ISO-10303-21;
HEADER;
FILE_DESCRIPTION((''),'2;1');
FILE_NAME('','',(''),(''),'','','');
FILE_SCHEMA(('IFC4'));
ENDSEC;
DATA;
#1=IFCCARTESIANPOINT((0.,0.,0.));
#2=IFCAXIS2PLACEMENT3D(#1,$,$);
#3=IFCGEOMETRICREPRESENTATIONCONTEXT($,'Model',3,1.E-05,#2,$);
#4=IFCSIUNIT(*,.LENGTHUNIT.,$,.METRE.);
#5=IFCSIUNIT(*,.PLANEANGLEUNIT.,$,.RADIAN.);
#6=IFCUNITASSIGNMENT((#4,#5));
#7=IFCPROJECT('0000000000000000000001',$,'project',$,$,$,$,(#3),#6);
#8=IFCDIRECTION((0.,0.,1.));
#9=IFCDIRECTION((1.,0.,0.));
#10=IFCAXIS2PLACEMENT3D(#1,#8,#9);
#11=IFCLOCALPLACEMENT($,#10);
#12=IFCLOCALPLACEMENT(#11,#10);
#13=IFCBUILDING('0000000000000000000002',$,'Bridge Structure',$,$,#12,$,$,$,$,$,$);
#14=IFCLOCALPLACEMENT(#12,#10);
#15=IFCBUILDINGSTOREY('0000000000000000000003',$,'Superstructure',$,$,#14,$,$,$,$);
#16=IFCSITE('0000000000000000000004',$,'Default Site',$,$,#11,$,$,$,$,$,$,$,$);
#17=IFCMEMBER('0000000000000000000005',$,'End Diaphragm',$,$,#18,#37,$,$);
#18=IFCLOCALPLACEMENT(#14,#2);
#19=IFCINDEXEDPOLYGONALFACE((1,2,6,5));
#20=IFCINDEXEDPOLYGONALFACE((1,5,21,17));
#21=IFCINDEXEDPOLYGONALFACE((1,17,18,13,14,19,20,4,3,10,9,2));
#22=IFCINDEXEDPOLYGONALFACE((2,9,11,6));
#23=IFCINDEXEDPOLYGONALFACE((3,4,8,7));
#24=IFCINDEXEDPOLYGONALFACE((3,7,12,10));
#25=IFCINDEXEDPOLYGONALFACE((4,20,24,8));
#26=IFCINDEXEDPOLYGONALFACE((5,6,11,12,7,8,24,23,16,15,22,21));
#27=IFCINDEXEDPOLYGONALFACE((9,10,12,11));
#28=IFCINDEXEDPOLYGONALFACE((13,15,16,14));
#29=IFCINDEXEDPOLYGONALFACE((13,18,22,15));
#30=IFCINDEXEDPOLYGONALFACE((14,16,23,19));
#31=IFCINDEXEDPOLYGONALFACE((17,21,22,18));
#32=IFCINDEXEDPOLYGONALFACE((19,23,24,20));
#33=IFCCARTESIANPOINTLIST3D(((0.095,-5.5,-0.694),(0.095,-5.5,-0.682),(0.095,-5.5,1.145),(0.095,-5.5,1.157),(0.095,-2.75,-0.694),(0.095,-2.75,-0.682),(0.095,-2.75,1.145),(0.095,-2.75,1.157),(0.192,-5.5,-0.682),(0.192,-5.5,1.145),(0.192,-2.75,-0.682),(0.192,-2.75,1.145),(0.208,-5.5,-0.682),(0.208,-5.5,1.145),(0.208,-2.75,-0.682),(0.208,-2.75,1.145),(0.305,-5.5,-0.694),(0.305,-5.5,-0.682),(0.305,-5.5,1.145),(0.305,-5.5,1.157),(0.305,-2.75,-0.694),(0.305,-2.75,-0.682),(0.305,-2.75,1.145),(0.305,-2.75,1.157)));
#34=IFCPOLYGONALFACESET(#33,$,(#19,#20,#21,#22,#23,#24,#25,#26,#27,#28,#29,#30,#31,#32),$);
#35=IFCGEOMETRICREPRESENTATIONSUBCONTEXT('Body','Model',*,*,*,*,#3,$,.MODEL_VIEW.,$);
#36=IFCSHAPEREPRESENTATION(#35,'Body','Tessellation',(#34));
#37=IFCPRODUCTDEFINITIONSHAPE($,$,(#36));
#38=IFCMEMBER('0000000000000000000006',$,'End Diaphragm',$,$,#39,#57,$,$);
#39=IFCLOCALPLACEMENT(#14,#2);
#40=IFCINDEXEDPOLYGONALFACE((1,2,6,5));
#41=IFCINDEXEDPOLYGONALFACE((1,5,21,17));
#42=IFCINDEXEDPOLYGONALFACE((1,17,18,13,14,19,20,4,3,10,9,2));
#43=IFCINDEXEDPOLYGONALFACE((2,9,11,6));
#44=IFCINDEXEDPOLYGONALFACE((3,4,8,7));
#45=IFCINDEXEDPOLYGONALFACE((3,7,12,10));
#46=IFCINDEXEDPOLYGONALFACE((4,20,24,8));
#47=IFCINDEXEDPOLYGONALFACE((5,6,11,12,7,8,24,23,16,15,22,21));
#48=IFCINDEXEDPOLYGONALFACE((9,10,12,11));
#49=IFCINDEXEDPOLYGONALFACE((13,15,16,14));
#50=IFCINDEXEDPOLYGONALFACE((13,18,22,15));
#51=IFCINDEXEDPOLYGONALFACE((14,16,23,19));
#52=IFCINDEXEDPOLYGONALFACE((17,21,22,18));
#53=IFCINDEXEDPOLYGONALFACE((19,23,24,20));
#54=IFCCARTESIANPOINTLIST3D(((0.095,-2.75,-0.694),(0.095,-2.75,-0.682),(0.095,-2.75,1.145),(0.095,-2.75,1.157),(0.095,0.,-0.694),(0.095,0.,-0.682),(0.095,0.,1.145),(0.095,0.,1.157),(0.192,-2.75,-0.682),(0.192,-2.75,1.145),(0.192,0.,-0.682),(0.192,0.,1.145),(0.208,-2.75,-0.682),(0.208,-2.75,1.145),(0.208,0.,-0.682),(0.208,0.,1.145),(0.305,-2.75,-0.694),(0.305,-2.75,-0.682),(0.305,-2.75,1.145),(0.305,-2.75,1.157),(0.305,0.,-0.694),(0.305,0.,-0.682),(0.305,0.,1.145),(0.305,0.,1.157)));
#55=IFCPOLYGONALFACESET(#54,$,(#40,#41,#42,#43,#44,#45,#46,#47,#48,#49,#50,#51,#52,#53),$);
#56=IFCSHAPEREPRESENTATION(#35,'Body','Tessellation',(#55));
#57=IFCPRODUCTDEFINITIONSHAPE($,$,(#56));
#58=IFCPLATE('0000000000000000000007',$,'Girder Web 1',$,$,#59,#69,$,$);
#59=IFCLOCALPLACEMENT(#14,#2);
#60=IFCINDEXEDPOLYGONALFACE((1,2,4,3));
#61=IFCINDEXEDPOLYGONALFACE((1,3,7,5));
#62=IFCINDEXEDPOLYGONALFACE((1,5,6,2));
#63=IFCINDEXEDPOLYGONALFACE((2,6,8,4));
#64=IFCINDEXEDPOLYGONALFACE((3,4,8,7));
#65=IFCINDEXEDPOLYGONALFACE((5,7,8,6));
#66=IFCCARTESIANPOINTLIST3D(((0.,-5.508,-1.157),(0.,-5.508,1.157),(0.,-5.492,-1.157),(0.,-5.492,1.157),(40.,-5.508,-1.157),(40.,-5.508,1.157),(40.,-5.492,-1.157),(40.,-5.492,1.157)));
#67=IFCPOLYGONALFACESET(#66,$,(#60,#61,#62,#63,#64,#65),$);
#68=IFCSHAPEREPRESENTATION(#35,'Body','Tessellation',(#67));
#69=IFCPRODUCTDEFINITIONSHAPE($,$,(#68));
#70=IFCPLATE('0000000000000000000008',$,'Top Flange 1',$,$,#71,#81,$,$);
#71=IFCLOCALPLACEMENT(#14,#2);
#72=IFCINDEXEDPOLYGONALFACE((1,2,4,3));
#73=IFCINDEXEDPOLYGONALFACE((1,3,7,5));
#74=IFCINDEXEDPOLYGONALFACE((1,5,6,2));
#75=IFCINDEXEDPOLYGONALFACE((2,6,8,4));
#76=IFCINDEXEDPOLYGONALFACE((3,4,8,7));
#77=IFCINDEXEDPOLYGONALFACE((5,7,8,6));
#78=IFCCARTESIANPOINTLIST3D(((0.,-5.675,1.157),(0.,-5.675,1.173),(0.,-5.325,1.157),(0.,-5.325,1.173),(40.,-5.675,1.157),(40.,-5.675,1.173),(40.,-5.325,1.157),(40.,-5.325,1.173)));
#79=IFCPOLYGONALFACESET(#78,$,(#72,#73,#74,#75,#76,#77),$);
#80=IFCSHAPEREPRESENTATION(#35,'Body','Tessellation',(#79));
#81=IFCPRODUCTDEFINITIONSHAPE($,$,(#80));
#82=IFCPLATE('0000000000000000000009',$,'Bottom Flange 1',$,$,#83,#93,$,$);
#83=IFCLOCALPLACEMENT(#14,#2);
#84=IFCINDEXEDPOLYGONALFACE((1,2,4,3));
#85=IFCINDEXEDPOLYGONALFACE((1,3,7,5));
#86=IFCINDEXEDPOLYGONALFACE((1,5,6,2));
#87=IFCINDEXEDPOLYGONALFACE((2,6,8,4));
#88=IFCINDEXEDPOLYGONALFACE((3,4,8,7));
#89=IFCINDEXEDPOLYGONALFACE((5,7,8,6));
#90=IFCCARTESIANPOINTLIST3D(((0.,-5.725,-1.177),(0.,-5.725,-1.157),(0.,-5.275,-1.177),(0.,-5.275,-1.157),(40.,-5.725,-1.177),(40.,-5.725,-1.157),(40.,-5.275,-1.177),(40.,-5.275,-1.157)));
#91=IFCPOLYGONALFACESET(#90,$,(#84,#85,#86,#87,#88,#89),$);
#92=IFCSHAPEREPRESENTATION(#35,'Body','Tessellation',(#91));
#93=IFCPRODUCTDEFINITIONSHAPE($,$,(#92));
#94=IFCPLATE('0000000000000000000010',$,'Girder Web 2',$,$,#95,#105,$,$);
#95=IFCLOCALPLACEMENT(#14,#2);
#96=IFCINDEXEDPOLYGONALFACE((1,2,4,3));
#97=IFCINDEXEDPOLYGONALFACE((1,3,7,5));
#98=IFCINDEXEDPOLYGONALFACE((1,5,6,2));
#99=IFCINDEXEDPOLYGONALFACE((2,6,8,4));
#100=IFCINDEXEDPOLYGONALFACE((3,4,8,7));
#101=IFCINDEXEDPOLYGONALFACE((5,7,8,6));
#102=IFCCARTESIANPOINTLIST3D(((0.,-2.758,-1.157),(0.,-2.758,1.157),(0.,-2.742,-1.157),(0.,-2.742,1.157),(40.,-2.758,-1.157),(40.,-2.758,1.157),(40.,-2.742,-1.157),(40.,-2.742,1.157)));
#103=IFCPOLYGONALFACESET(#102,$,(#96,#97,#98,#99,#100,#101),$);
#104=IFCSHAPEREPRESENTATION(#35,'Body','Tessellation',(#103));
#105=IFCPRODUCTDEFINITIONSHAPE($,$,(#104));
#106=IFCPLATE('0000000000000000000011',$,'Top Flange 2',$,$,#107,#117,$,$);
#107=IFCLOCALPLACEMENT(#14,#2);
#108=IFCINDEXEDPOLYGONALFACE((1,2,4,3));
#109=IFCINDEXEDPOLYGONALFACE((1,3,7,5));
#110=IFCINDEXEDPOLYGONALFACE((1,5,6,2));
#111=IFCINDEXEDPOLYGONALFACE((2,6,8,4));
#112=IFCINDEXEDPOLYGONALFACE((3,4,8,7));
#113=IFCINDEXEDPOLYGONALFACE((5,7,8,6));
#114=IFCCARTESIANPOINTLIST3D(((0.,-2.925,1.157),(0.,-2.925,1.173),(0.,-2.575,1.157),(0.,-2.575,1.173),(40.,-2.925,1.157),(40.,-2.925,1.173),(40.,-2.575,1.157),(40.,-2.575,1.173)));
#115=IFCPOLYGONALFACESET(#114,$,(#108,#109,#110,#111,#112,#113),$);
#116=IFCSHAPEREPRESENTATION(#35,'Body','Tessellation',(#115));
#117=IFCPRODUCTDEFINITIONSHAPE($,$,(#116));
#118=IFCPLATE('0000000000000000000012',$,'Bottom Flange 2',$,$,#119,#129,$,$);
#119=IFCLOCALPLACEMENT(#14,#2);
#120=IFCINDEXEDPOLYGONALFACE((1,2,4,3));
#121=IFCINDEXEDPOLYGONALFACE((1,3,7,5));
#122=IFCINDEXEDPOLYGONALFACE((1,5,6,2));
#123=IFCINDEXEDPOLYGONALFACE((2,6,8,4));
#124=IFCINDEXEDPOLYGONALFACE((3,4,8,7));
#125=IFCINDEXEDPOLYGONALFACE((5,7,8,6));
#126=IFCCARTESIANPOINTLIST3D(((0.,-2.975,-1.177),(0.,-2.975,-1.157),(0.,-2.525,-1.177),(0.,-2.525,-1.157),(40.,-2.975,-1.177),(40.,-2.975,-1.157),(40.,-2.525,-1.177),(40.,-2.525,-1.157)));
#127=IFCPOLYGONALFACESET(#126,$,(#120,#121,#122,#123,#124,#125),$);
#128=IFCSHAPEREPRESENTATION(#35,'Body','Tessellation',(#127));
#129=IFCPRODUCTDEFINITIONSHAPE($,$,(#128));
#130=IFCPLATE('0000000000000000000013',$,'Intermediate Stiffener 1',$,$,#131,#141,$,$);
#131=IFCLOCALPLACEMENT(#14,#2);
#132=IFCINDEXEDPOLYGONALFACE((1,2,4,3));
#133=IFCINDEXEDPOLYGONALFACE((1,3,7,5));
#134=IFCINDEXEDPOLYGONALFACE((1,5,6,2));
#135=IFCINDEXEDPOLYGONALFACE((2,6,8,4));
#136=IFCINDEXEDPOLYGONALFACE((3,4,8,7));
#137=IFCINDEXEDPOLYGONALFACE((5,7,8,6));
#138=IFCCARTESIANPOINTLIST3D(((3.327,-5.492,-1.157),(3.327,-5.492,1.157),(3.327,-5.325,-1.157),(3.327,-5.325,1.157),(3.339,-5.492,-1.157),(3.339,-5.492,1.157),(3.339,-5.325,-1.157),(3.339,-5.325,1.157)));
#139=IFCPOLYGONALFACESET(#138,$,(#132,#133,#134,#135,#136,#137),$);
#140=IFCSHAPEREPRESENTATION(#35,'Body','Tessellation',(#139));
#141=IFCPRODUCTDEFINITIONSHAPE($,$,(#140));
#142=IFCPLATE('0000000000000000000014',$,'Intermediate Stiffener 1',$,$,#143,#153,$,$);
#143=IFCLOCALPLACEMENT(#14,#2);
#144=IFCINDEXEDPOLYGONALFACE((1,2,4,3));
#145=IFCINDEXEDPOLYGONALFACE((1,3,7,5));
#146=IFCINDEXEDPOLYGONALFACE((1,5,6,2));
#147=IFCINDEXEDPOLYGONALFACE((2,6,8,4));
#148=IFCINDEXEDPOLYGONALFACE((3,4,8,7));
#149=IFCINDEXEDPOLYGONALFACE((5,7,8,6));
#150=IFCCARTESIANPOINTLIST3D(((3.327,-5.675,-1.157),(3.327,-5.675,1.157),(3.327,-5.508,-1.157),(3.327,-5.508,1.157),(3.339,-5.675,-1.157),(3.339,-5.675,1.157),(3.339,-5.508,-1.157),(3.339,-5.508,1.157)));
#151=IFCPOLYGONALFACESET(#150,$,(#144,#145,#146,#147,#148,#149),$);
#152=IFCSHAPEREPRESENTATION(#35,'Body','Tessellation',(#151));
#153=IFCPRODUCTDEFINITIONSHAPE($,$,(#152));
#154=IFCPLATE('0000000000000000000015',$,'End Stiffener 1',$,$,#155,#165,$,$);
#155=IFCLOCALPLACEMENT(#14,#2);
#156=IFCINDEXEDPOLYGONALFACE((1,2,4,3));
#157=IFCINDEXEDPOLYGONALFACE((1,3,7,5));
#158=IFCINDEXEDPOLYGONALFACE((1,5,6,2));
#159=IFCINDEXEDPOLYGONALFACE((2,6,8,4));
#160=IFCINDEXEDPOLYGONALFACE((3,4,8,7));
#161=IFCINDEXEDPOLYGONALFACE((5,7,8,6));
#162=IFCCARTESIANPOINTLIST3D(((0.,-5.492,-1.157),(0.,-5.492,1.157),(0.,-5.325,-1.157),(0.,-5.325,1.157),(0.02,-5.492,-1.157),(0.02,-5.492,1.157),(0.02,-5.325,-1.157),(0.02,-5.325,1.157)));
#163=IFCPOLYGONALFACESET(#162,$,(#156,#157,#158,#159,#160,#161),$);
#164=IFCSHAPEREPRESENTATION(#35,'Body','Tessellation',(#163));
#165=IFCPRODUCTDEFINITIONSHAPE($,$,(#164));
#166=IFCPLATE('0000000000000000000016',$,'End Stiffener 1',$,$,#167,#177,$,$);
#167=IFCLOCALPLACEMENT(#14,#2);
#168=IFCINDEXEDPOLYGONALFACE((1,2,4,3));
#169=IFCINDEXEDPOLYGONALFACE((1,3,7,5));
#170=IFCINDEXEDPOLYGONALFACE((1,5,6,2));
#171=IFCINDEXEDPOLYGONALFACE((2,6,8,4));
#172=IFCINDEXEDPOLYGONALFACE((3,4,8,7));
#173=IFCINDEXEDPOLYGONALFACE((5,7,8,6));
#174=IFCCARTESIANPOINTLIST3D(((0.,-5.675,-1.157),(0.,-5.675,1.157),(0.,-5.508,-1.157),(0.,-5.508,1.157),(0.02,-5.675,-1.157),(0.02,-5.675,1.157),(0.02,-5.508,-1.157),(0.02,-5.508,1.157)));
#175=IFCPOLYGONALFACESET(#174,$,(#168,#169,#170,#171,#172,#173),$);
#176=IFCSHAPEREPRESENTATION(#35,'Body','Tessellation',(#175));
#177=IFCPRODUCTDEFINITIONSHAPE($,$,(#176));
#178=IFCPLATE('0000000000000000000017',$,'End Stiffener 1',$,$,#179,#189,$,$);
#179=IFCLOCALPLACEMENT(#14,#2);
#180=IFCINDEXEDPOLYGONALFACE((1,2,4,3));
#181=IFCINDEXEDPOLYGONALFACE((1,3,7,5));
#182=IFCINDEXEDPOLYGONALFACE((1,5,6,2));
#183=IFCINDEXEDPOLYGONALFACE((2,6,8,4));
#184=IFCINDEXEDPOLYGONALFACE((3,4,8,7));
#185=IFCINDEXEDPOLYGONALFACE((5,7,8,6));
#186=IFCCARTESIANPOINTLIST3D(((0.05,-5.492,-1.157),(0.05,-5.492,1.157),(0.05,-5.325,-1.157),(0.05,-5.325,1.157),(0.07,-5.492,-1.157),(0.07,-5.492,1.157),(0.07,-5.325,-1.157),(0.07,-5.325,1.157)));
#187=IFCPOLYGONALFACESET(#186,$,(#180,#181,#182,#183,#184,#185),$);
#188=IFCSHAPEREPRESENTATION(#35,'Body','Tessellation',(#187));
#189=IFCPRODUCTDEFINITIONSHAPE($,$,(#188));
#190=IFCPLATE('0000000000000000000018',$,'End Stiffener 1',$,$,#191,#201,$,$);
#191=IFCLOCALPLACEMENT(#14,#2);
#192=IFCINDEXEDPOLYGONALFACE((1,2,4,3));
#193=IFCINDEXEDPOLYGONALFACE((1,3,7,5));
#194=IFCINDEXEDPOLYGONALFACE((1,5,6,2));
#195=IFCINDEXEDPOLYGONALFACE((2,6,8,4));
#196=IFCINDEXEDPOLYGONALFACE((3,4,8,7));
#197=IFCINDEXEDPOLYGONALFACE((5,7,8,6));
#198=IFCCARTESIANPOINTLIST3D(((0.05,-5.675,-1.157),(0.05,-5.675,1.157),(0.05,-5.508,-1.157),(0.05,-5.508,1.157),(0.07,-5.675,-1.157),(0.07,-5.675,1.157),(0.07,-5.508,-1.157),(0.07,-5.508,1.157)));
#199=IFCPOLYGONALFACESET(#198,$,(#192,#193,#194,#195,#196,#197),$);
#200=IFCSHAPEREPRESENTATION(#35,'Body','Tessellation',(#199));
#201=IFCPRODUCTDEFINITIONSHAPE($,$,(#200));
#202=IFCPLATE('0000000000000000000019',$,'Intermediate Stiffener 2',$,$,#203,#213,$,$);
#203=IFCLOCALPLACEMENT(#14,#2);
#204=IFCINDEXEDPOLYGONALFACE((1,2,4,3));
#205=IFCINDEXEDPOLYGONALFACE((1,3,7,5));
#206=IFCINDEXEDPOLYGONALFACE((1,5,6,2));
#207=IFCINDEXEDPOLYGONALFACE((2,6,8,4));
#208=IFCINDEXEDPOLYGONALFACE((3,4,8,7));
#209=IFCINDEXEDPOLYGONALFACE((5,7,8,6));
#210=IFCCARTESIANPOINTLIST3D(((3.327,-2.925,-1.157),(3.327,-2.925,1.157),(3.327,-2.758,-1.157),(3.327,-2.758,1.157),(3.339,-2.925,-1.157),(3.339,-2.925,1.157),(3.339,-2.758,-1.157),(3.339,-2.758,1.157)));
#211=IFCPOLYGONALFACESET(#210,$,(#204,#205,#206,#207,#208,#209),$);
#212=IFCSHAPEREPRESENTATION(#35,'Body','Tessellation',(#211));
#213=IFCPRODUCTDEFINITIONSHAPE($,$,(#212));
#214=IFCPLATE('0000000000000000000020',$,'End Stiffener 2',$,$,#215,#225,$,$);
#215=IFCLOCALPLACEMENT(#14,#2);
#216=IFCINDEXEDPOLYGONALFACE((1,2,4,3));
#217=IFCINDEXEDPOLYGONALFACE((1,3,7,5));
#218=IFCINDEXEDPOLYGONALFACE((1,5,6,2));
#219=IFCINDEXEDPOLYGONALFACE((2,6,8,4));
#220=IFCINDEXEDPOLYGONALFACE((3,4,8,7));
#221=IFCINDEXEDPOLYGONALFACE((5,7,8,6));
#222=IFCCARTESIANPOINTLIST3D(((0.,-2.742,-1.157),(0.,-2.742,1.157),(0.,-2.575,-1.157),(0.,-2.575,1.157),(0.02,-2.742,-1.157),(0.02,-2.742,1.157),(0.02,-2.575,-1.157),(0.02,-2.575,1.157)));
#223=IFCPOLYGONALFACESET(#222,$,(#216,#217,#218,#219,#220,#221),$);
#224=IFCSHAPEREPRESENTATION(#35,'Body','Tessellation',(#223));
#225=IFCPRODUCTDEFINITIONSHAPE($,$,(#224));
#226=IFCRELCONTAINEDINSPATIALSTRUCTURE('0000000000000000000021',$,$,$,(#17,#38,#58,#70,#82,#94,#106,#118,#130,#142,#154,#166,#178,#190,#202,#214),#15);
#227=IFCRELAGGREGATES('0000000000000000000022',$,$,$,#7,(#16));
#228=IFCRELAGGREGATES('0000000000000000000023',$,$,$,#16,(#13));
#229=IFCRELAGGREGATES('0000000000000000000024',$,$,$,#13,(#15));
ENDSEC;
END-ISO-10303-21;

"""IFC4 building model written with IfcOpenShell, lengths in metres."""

from ifc_helpers import new_model, si_unit, frame, origin, origin_with_axes, origin_2d_with_axis, place, context, subcontext, project, spatial, rectangle, i_section, extrude, element, save


model = new_model("IFC4")

# Units and contexts
model_context = context("Model", 3, precision=1e-05, world=origin())
body_context = subcontext(model_context, "Body", "Model", "MODEL_VIEW")
ifc_project = project(units=[si_unit("LENGTHUNIT", "METRE"), si_unit("PLANEANGLEUNIT", "RADIAN")], contexts=[model_context])

# Site, building, storey
site_placement = place(None, origin_with_axes())
site = spatial("IfcSite", under=ifc_project, at=site_placement, Name="Default Site")
building_placement = place(site_placement, origin_with_axes())
building = spatial("IfcBuilding", under=site, at=building_placement, Name="Bridge Structure")
storey_placement = place(building_placement, origin_with_axes())
storey = spatial("IfcBuildingStorey", under=building, at=storey_placement, Name="Superstructure")

# Members
for number, where, z_axis, x_axis, name in (
    (1, (0.2, -5.5, 0.2315), (0.0, 1.0, 0.0), (-1.0, 0.0, 0.0), "End Diaphragm"),
    (2, (0.2, -2.75, 0.2315), (0.0, 1.0, 0.0), (-1.0, 0.0, 0.0), "End Diaphragm"),
):
    element("IfcMember", number, at=place(storey_placement, frame(where, z_axis=z_axis, x_axis=x_axis)), inside=storey, Name=name, context=body_context, shape_type="SweptSolid", body=[
        extrude(i_section(OverallWidth=0.21, OverallDepth=1.851, WebThickness=0.016, FlangeThickness=0.012, at=origin_2d_with_axis()), origin_with_axes(), (0.0, 0.0, 1.0), 2.75),
    ])

# Plates
plate_1_placement = place(storey_placement, frame((0.0, -5.5, 0.0), z_axis=(1.0, 0.0, 0.0), x_axis=(0.0, 1.0, 0.0)))
element("IfcPlate", 3, at=plate_1_placement, inside=storey, Name="Girder Web 1", context=body_context, shape_type="SweptSolid", body=[
    extrude(rectangle(XDim=0.016, YDim=2.314, at=origin_2d_with_axis()), origin_with_axes(), (0.0, 0.0, 1.0), 40.0),
])
plate_2_placement = place(storey_placement, frame((0.0, -5.5, 1.165), z_axis=(1.0, 0.0, 0.0), x_axis=(0.0, 1.0, 0.0)))
element("IfcPlate", 4, at=plate_2_placement, inside=storey, Name="Top Flange 1", context=body_context, shape_type="SweptSolid", body=[
    extrude(rectangle(XDim=0.35, YDim=0.016, at=origin_2d_with_axis()), origin_with_axes(), (0.0, 0.0, 1.0), 40.0),
])
plate_3_placement = place(storey_placement, frame((0.0, -5.5, -1.167), z_axis=(1.0, 0.0, 0.0), x_axis=(0.0, 1.0, 0.0)))
element("IfcPlate", 5, at=plate_3_placement, inside=storey, Name="Bottom Flange 1", context=body_context, shape_type="SweptSolid", body=[
    extrude(rectangle(XDim=0.45, YDim=0.02, at=origin_2d_with_axis()), origin_with_axes(), (0.0, 0.0, 1.0), 40.0),
])
plate_4_placement = place(storey_placement, frame((0.0, -2.75, 0.0), z_axis=(1.0, 0.0, 0.0), x_axis=(0.0, 1.0, 0.0)))
element("IfcPlate", 6, at=plate_4_placement, inside=storey, Name="Girder Web 2", context=body_context, shape_type="SweptSolid", body=[
    extrude(rectangle(XDim=0.016, YDim=2.314, at=origin_2d_with_axis()), origin_with_axes(), (0.0, 0.0, 1.0), 40.0),
])
plate_5_placement = place(storey_placement, frame((0.0, -2.75, 1.165), z_axis=(1.0, 0.0, 0.0), x_axis=(0.0, 1.0, 0.0)))
element("IfcPlate", 7, at=plate_5_placement, inside=storey, Name="Top Flange 2", context=body_context, shape_type="SweptSolid", body=[
    extrude(rectangle(XDim=0.35, YDim=0.016, at=origin_2d_with_axis()), origin_with_axes(), (0.0, 0.0, 1.0), 40.0),
])
plate_6_placement = place(storey_placement, frame((0.0, -2.75, -1.167), z_axis=(1.0, 0.0, 0.0), x_axis=(0.0, 1.0, 0.0)))
element("IfcPlate", 8, at=plate_6_placement, inside=storey, Name="Bottom Flange 2", context=body_context, shape_type="SweptSolid", body=[
    extrude(rectangle(XDim=0.45, YDim=0.02, at=origin_2d_with_axis()), origin_with_axes(), (0.0, 0.0, 1.0), 40.0),
])
for number, where, z_axis, x_axis, name in (
    (9, (3.333, -5.4085, -1.157), (0.0, 0.0, 1.0), (1.0, 0.0, 0.0), "Intermediate Stiffener 1"),
    (10, (3.333, -5.5915, -1.157), (0.0, 0.0, 1.0), (1.0, 0.0, 0.0), "Intermediate Stiffener 1"),
):
    element("IfcPlate", number, at=place(storey_placement, frame(where, z_axis=z_axis, x_axis=x_axis)), inside=storey, Name=name, context=body_context, shape_type="SweptSolid", body=[
        extrude(rectangle(XDim=0.012, YDim=0.167, at=origin_2d_with_axis()), origin_with_axes(), (0.0, 0.0, 1.0), 2.314),
    ])
for number, where, z_axis, x_axis, name in (
    (11, (0.01, -5.4085, -1.157), (0.0, 0.0, 1.0), (1.0, 0.0, 0.0), "End Stiffener 1"),
    (12, (0.01, -5.5915, -1.157), (0.0, 0.0, 1.0), (1.0, 0.0, 0.0), "End Stiffener 1"),
    (13, (0.06, -5.4085, -1.157), (0.0, 0.0, 1.0), (1.0, 0.0, 0.0), "End Stiffener 1"),
    (14, (0.06, -5.5915, -1.157), (0.0, 0.0, 1.0), (1.0, 0.0, 0.0), "End Stiffener 1"),
):
    element("IfcPlate", number, at=place(storey_placement, frame(where, z_axis=z_axis, x_axis=x_axis)), inside=storey, Name=name, context=body_context, shape_type="SweptSolid", body=[
        extrude(rectangle(XDim=0.02, YDim=0.167, at=origin_2d_with_axis()), origin_with_axes(), (0.0, 0.0, 1.0), 2.314),
    ])
plate_7_placement = place(storey_placement, frame((3.333, -2.8415, -1.157), z_axis=(0.0, 0.0, 1.0), x_axis=(1.0, 0.0, 0.0)))
element("IfcPlate", 15, at=plate_7_placement, inside=storey, Name="Intermediate Stiffener 2", context=body_context, shape_type="SweptSolid", body=[
    extrude(rectangle(XDim=0.012, YDim=0.167, at=origin_2d_with_axis()), origin_with_axes(), (0.0, 0.0, 1.0), 2.314),
])
for number, where, z_axis, x_axis, name in (
    (16, (0.01, -2.6585, -1.157), (0.0, 0.0, 1.0), (1.0, 0.0, 0.0), "End Stiffener 2"),
):
    element("IfcPlate", number, at=place(storey_placement, frame(where, z_axis=z_axis, x_axis=x_axis)), inside=storey, Name=name, context=body_context, shape_type="SweptSolid", body=[
        extrude(rectangle(XDim=0.02, YDim=0.167, at=origin_2d_with_axis()), origin_with_axes(), (0.0, 0.0, 1.0), 2.314),
    ])

save(model, "model.ifc")
